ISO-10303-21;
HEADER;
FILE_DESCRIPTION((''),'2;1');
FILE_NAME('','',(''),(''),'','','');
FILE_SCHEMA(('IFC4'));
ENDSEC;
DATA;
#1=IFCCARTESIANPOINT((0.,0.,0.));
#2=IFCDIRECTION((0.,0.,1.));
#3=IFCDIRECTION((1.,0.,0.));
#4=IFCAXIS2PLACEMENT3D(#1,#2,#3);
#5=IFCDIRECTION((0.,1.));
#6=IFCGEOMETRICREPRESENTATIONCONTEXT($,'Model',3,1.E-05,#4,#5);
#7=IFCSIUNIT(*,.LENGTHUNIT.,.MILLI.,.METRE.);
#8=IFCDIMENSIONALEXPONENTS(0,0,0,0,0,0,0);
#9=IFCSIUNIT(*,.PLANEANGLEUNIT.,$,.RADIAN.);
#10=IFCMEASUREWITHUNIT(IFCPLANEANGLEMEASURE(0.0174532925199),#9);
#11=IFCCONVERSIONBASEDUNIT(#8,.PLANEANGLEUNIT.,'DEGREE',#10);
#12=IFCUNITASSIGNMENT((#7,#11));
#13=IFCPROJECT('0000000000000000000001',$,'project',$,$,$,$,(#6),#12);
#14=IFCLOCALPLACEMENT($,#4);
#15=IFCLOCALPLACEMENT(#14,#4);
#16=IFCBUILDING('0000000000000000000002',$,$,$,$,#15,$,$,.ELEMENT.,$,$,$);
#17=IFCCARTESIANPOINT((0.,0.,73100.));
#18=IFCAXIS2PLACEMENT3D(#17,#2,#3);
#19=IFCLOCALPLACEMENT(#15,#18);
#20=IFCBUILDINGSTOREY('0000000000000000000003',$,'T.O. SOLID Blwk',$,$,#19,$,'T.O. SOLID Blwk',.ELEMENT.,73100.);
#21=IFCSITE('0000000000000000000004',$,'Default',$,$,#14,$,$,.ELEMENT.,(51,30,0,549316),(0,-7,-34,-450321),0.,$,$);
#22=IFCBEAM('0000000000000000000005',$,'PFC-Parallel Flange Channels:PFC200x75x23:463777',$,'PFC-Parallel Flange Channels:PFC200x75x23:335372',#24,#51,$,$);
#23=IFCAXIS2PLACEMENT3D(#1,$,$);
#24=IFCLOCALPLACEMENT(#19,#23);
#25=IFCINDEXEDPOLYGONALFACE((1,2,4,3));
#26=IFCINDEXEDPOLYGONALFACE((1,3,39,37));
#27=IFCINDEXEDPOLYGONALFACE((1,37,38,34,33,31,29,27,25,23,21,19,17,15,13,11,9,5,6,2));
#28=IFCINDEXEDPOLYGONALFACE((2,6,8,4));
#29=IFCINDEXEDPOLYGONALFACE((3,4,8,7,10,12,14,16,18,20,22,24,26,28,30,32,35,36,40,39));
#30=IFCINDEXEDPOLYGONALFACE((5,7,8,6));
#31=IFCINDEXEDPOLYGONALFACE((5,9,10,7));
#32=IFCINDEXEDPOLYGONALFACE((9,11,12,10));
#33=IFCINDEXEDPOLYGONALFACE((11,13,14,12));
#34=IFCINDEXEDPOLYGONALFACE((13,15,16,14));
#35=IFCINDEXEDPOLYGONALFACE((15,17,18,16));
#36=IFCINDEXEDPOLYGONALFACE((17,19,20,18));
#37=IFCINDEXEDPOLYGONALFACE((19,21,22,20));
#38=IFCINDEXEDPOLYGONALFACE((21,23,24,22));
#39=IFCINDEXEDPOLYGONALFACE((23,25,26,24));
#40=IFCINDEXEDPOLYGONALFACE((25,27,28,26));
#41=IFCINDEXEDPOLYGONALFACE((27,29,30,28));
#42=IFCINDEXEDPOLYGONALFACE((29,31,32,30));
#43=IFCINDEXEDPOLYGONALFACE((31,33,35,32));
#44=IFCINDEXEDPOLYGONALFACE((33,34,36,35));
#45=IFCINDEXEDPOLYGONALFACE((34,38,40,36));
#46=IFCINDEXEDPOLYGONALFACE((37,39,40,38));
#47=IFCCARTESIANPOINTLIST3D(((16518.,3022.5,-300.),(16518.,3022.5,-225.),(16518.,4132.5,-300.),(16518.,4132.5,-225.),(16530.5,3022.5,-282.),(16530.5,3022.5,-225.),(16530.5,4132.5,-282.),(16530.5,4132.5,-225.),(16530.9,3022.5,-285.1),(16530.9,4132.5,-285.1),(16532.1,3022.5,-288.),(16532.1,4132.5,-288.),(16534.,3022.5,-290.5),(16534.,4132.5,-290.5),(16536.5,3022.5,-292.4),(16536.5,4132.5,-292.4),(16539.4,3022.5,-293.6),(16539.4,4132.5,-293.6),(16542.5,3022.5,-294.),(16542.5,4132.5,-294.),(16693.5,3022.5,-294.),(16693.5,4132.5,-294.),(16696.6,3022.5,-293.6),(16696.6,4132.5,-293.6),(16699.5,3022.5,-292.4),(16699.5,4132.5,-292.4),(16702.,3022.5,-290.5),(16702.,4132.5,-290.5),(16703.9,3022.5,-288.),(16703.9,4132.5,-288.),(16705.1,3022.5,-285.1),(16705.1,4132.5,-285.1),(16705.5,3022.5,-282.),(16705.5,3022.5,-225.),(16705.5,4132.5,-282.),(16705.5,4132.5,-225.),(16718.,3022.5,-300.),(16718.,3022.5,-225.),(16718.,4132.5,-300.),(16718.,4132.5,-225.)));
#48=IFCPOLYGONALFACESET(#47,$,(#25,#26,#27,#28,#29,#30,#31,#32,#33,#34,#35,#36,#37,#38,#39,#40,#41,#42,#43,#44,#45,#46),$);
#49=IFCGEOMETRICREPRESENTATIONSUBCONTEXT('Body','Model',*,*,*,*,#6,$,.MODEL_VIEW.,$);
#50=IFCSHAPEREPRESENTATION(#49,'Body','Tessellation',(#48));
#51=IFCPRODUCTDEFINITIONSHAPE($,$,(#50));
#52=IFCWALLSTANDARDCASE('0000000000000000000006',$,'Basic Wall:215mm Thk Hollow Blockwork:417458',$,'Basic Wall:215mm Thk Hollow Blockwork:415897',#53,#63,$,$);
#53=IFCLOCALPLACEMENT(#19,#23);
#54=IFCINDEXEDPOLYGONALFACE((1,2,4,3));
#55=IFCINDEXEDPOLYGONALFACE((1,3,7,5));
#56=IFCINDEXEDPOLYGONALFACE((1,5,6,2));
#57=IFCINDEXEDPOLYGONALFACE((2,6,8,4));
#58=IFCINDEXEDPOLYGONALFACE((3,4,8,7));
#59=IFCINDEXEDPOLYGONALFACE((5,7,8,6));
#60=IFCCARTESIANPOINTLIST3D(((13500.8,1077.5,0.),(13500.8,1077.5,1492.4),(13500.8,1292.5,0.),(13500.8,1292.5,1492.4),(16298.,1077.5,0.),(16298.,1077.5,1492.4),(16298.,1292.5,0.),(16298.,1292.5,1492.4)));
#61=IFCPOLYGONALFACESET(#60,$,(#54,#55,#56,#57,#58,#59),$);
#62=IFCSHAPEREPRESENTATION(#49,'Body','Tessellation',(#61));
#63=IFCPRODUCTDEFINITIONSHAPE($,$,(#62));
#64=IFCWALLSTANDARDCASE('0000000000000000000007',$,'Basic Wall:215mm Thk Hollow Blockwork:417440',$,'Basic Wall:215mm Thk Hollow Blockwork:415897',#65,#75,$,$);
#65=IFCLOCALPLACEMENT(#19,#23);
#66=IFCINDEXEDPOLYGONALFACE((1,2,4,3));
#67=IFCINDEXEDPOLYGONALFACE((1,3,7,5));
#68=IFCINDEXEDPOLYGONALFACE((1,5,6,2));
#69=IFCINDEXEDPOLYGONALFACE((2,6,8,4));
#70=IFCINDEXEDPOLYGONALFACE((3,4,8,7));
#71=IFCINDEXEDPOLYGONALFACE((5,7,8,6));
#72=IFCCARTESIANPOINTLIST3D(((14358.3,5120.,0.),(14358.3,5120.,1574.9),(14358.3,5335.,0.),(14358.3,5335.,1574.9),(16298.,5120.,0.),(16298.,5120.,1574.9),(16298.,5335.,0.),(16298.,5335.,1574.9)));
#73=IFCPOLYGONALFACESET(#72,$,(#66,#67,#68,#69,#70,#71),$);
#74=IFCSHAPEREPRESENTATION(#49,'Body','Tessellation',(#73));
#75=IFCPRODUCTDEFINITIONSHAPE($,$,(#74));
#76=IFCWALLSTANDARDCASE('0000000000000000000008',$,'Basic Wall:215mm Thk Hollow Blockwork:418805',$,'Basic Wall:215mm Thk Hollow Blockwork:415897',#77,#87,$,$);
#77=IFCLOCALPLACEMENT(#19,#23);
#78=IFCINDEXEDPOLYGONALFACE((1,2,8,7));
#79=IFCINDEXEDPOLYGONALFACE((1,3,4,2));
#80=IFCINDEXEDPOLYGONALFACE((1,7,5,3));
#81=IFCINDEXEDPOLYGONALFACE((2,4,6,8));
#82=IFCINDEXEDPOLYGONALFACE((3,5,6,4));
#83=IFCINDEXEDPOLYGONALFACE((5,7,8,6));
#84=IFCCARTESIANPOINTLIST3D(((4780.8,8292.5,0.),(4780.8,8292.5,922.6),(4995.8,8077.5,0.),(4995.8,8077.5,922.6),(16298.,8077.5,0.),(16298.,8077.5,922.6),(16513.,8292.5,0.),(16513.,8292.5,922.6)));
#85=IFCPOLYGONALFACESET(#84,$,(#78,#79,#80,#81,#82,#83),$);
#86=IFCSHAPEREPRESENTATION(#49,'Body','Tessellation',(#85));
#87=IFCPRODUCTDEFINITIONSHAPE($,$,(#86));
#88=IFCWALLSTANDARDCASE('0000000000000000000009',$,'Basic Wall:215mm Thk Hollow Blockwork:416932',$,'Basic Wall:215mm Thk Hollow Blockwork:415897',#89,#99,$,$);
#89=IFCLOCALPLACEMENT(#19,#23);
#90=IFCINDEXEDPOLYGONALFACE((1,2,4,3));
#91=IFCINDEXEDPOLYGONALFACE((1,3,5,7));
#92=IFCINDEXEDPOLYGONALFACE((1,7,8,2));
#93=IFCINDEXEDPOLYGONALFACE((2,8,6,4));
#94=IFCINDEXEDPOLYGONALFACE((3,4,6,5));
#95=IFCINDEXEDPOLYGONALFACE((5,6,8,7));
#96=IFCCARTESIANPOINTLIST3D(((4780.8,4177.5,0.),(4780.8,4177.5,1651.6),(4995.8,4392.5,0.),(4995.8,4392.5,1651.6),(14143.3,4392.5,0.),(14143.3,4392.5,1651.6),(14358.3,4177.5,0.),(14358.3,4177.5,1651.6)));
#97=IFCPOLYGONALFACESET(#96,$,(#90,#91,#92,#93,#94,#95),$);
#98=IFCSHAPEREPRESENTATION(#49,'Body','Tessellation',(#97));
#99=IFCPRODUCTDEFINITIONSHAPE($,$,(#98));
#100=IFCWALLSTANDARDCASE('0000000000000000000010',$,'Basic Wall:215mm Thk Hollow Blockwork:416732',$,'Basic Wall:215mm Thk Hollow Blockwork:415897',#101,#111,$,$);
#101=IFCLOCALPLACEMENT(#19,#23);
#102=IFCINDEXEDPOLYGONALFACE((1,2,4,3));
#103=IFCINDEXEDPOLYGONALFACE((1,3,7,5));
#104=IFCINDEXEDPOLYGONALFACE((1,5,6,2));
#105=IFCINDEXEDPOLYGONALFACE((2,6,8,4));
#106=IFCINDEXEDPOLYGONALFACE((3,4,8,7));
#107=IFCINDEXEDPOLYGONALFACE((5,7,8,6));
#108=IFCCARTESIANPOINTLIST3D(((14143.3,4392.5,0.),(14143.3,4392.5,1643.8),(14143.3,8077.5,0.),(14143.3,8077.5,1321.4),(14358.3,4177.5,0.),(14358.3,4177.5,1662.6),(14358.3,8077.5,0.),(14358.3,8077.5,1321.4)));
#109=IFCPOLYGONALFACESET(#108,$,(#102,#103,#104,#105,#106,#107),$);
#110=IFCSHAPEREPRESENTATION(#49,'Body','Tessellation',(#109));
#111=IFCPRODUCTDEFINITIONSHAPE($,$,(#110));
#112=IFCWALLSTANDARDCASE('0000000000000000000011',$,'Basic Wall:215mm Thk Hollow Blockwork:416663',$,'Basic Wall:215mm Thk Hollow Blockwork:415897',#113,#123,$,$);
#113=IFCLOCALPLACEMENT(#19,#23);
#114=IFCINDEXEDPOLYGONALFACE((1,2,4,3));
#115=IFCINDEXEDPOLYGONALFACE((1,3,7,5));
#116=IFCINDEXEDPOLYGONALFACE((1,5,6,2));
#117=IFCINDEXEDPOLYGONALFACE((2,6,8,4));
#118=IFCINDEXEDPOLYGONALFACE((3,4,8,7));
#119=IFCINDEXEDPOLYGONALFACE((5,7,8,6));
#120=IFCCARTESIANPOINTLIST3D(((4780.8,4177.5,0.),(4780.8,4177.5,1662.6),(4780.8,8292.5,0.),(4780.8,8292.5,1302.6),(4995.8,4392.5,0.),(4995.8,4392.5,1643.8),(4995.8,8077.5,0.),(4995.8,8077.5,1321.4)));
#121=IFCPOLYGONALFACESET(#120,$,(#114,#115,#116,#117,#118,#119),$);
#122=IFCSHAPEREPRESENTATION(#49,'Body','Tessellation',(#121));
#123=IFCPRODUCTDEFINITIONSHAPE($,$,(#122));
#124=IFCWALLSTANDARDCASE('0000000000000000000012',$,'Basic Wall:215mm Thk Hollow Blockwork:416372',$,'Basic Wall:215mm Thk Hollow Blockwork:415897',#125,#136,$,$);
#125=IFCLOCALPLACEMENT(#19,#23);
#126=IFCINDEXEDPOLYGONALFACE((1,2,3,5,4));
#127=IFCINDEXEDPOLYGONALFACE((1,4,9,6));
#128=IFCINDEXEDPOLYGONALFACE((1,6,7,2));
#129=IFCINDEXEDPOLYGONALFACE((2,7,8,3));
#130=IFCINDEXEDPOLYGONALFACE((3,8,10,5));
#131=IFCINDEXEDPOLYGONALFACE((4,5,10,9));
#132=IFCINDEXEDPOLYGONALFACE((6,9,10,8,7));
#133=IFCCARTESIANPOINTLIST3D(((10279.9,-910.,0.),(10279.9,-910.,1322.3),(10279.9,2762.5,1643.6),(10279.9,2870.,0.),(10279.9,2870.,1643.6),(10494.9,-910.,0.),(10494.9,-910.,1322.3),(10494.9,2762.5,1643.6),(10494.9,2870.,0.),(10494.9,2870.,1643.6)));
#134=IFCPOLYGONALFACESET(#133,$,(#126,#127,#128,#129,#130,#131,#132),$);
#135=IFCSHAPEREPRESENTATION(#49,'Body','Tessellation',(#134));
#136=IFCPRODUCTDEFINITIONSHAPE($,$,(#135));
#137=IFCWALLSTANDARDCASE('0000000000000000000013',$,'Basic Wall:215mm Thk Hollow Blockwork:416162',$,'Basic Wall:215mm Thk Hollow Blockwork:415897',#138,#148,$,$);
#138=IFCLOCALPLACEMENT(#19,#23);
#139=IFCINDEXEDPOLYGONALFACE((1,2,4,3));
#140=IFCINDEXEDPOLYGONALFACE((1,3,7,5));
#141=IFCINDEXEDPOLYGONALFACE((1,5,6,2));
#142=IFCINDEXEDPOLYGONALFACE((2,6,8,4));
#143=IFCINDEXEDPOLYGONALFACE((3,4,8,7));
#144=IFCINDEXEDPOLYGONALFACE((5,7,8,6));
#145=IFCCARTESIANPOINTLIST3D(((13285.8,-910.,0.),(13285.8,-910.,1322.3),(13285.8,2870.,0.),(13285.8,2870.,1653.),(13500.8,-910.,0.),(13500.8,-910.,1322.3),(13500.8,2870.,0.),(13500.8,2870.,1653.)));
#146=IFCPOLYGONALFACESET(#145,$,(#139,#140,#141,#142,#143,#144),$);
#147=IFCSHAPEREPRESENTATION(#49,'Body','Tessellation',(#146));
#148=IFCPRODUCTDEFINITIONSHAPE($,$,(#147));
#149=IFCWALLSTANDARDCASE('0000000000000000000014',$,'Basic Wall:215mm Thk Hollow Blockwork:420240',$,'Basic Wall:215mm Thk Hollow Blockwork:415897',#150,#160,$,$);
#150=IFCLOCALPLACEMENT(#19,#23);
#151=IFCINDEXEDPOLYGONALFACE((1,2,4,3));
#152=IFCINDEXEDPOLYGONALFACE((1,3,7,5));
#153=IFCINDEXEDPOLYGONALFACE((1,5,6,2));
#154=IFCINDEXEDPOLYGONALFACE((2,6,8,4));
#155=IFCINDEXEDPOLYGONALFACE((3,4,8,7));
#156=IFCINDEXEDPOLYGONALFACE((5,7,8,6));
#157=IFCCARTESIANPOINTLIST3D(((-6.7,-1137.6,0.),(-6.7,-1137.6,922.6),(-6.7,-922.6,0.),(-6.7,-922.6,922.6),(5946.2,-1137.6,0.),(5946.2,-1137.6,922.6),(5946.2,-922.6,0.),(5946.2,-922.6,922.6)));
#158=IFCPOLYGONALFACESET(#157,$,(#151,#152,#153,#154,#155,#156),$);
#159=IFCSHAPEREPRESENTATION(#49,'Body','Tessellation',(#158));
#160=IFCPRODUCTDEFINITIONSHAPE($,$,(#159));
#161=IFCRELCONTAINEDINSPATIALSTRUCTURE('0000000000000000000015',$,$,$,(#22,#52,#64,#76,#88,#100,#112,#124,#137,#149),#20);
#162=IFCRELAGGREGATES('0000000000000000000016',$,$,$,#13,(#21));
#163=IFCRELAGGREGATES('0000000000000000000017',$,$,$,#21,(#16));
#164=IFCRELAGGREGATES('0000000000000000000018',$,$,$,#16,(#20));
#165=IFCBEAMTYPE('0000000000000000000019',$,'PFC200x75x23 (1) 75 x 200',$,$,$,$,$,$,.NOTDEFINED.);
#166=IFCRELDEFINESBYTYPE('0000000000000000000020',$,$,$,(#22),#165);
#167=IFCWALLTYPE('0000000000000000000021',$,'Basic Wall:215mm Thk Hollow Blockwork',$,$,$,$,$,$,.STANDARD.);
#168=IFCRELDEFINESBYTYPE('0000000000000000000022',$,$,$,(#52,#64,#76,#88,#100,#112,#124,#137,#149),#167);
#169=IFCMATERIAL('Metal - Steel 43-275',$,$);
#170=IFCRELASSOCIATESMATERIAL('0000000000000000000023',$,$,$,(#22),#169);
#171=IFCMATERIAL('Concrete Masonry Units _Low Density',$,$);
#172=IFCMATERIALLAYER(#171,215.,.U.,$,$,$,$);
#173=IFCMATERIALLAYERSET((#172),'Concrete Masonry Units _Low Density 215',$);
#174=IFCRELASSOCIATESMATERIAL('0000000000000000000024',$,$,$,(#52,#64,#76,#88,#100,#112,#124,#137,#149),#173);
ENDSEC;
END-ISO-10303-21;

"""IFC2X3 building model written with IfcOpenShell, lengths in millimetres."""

from ifc_helpers import new_model, entity, si_unit, converted_unit, point, direction, frame, frame_2d, origin_with_axes, place, context, subcontext, project, spatial, polyline, circle_curve, parameter, trimmed, segment, composite_curve, outline, extrude, clip, halfspace, material, layer, layer_set, layer_usage, type_object, element, save


model = new_model("IFC2X3")

# Units and contexts
model_context = context("Model", 3, precision=1e-05, world=origin_with_axes(), true_north=direction((0.0, 1.0)))
body_context = subcontext(model_context, "Body", "Model", "MODEL_VIEW")
ifc_project = project(units=[si_unit("LENGTHUNIT", "METRE", prefix="MILLI"), converted_unit("PLANEANGLEUNIT", "DEGREE", entity("IfcPlaneAngleMeasure", 0.0174532925199), si_unit("PLANEANGLEUNIT", "RADIAN"), dimensions=[0, 0, 0, 0, 0, 0, 0])], contexts=[model_context])

# Site, building, storey
site_placement = place(None, origin_with_axes())
site = spatial("IfcSite", under=ifc_project, at=site_placement, Name="Default", CompositionType="ELEMENT", RefLatitude=(51, 30, 0, 549316), RefLongitude=(0, -7, -34, -450321), RefElevation=0.0)
building_placement = place(site_placement, origin_with_axes())
building = spatial("IfcBuilding", under=site, at=building_placement, CompositionType="ELEMENT")
storey_placement = place(building_placement, frame((0.0, 0.0, 73100.0), z_axis=(0.0, 0.0, 1.0), x_axis=(1.0, 0.0, 0.0)))
storey = spatial("IfcBuildingStorey", under=building, at=storey_placement, Name="T.O. SOLID Blwk", LongName="T.O. SOLID Blwk", CompositionType="ELEMENT", Elevation=73100.0)

# Beam
ifc_material_1 = material(Name="Metal - Steel 43-275")
beam_type = type_object("IfcBeamType", Name="PFC200x75x23 (1) 75 x 200", PredefinedType="NOTDEFINED")
beam_placement = place(storey_placement, frame((16618.0, 3022.5, -265.2), z_axis=(0.0, 0.0, 1.0), x_axis=(1.0, 0.0, 0.0)))
element("IfcBeam", 1, at=beam_placement, inside=storey, type_object=beam_type, material=ifc_material_1, Name="PFC-Parallel Flange Channels:PFC200x75x23:463777", ObjectType="PFC-Parallel Flange Channels:PFC200x75x23:335372", context=body_context, shape_type="SweptSolid", body=[
    extrude(outline(composite_curve([segment(polyline([(-40.2, -100.0), (34.8, -100.0), (34.8, 100.0), (-40.2, 100.0), (-40.2, 87.5), (16.8, 87.5)]), True, "CONTINUOUS"), segment(trimmed(circle_curve(frame_2d((16.8, 75.5), x_axis=(1.0, 0.0)), 12.0), [point((16.8, 87.5)), parameter(90.0)], [point((28.8, 75.5)), parameter(0.0)], False, "CARTESIAN"), True, "CONTINUOUS"), segment(polyline([(28.8, 75.5), (28.8, -75.5)]), True, "CONTINUOUS"), segment(trimmed(circle_curve(frame_2d((16.8, -75.5), x_axis=(0.0, -1.0)), 12.0), [point((28.8, -75.5)), parameter(90.0)], [point((16.8, -87.5)), parameter(0.0)], False, "CARTESIAN"), True, "CONTINUOUS"), segment(polyline([(16.8, -87.5), (-40.2, -87.5), (-40.2, -100.0)]), True, "CONTINUOUS")], self_intersect=False)), frame((0.0, 1110.0, 0.0), z_axis=(0.0, -1.0, 0.0), x_axis=(0.0, 0.0, -1.0)), (0.0, 0.0, 1.0), 1110.0),
])

# Shared definitions
ifc_material_2 = material(Name="Concrete Masonry Units _Low Density")
ifc_layer = layer(ifc_material_2, 215.0, ventilated="UNKNOWN")
ifc_layer_set = layer_set([ifc_layer], Name="Concrete Masonry Units _Low Density 215")
wall_type = type_object("IfcWallType", Name="Basic Wall:215mm Thk Hollow Blockwork", PredefinedType="STANDARD")

# Walls
ifc_layer_usage_1 = layer_usage(ifc_layer_set, "AXIS2", "POSITIVE", -107.5)
wall_1_placement = place(storey_placement, frame((13393.3, 1185.0, 0.0), z_axis=(0.0, 0.0, 1.0), x_axis=(1.0, 0.0, 0.0)))
element("IfcWallStandardCase", 2, at=wall_1_placement, inside=storey, type_object=wall_type, material=ifc_layer_usage_1, Name="Basic Wall:215mm Thk Hollow Blockwork:417458", ObjectType="Basic Wall:215mm Thk Hollow Blockwork:415897", context=body_context, shape_type="SweptSolid", body=[
    extrude(outline(polyline([(107.5, -107.5), (2904.8, -107.5), (2904.8, 107.5), (107.5, 107.5), (107.5, -107.5)])), origin_with_axes(), (0.0, 0.0, 1.0), 1492.4),
])
ifc_layer_usage_2 = layer_usage(ifc_layer_set, "AXIS2", "POSITIVE", -107.5)
wall_2_placement = place(storey_placement, frame((14250.8, 5227.5, 0.0), z_axis=(0.0, 0.0, 1.0), x_axis=(1.0, 0.0, 0.0)))
element("IfcWallStandardCase", 3, at=wall_2_placement, inside=storey, type_object=wall_type, material=ifc_layer_usage_2, Name="Basic Wall:215mm Thk Hollow Blockwork:417440", ObjectType="Basic Wall:215mm Thk Hollow Blockwork:415897", context=body_context, shape_type="SweptSolid", body=[
    extrude(outline(polyline([(107.5, -107.5), (2047.3, -107.5), (2047.3, 107.5), (107.5, 107.5), (107.5, -107.5)])), origin_with_axes(), (0.0, 0.0, 1.0), 1574.9),
])
ifc_layer_usage_3 = layer_usage(ifc_layer_set, "AXIS2", "POSITIVE", -107.5)
wall_3_placement = place(storey_placement, frame((4888.3, 8185.0, 0.0), z_axis=(0.0, 0.0, 1.0), x_axis=(1.0, 0.0, 0.0)))
element("IfcWallStandardCase", 4, at=wall_3_placement, inside=storey, type_object=wall_type, material=ifc_layer_usage_3, Name="Basic Wall:215mm Thk Hollow Blockwork:418805", ObjectType="Basic Wall:215mm Thk Hollow Blockwork:415897", context=body_context, shape_type="SweptSolid", body=[
    extrude(outline(polyline([(107.5, -107.5), (11409.8, -107.5), (11624.8, 107.5), (-107.5, 107.5), (107.5, -107.5)])), origin_with_axes(), (0.0, 0.0, 1.0), 922.6),
])
ifc_layer_usage_4 = layer_usage(ifc_layer_set, "AXIS2", "POSITIVE", -107.5)
wall_4_placement = place(storey_placement, frame((4888.3, 4285.0, 0.0), z_axis=(0.0, 0.0, 1.0), x_axis=(1.0, 0.0, 0.0)))
element("IfcWallStandardCase", 5, at=wall_4_placement, inside=storey, type_object=wall_type, material=ifc_layer_usage_4, Name="Basic Wall:215mm Thk Hollow Blockwork:416932", ObjectType="Basic Wall:215mm Thk Hollow Blockwork:415897", context=body_context, shape_type="SweptSolid", body=[
    extrude(outline(polyline([(-107.5, -107.5), (9470.0, -107.5), (9255.0, 107.5), (107.5, 107.5), (-107.5, -107.5)])), origin_with_axes(), (0.0, 0.0, 1.0), 1651.6),
])
ifc_layer_usage_5 = layer_usage(ifc_layer_set, "AXIS2", "POSITIVE", -107.5)
wall_5_placement = place(storey_placement, frame((14250.8, 4285.0, 0.0), z_axis=(0.0, 0.0, 1.0), x_axis=(0.0, 1.0, 0.0)))
element("IfcWallStandardCase", 6, at=wall_5_placement, inside=storey, type_object=wall_type, material=ifc_layer_usage_5, Name="Basic Wall:215mm Thk Hollow Blockwork:416732", ObjectType="Basic Wall:215mm Thk Hollow Blockwork:415897", context=body_context, shape_type="Clipping", body=[
    clip(extrude(outline(polyline([(-107.5, -107.5), (3792.5, -107.5), (3792.5, 107.5), (107.5, 107.5), (-107.5, -107.5)])), origin_with_axes(), (0.0, 0.0, 1.0), 1662.6), halfspace(frame((143.5, 0.0, 1640.7), z_axis=(-0.087156, 0.0, -0.996195), x_axis=(0.0, 1.0, 0.0)), True)),
])
ifc_layer_usage_6 = layer_usage(ifc_layer_set, "AXIS2", "POSITIVE", -107.5)
wall_6_placement = place(storey_placement, frame((4888.3, 8185.0, 0.0), z_axis=(0.0, 0.0, 1.0), x_axis=(0.0, -1.0, 0.0)))
element("IfcWallStandardCase", 7, at=wall_6_placement, inside=storey, type_object=wall_type, material=ifc_layer_usage_6, Name="Basic Wall:215mm Thk Hollow Blockwork:416663", ObjectType="Basic Wall:215mm Thk Hollow Blockwork:415897", context=body_context, shape_type="Clipping", body=[
    clip(extrude(outline(polyline([(-107.5, -107.5), (4007.5, -107.5), (3792.5, 107.5), (107.5, 107.5), (-107.5, -107.5)])), origin_with_axes(), (0.0, 0.0, 1.0), 1662.6), halfspace(frame((-113.9, 0.0, 1302.0), z_axis=(0.087156, 0.0, -0.996195), x_axis=(0.0, 1.0, 0.0)), True)),
])
ifc_layer_usage_7 = layer_usage(ifc_layer_set, "AXIS2", "POSITIVE", -107.5)
wall_7_placement = place(storey_placement, frame((10387.4, -910.0, 0.0), z_axis=(0.0, 0.0, 1.0), x_axis=(0.0, 1.0, 0.0)))
element("IfcWallStandardCase", 8, at=wall_7_placement, inside=storey, type_object=wall_type, material=ifc_layer_usage_7, Name="Basic Wall:215mm Thk Hollow Blockwork:416372", ObjectType="Basic Wall:215mm Thk Hollow Blockwork:415897", context=body_context, shape_type="Clipping", body=[
    clip(extrude(outline(polyline([(0.0, -107.5), (3780.0, -107.5), (3780.0, 107.5), (0.0, 107.5), (0.0, -107.5)])), origin_with_axes(), (0.0, 0.0, 1.0), 1643.6), halfspace(frame((-114.8, 0.0, 1312.3), z_axis=(0.087156, 0.0, -0.996195), x_axis=(0.0, 1.0, 0.0)), True)),
])
ifc_layer_usage_8 = layer_usage(ifc_layer_set, "AXIS2", "POSITIVE", -107.5)
wall_8_placement = place(storey_placement, frame((13393.3, 2870.0, 0.0), z_axis=(0.0, 0.0, 1.0), x_axis=(0.0, -1.0, 0.0)))
element("IfcWallStandardCase", 9, at=wall_8_placement, inside=storey, type_object=wall_type, material=ifc_layer_usage_8, Name="Basic Wall:215mm Thk Hollow Blockwork:416162", ObjectType="Basic Wall:215mm Thk Hollow Blockwork:415897", context=body_context, shape_type="Clipping", body=[
    clip(extrude(outline(polyline([(0.0, -107.5), (3780.0, -107.5), (3780.0, 107.5), (0.0, 107.5), (0.0, -107.5)])), origin_with_axes(), (0.0, 0.0, 1.0), 1662.4), halfspace(frame((143.5, 0.0, 1640.5), z_axis=(-0.087156, 0.0, -0.996195), x_axis=(0.0, 1.0, 0.0)), True)),
])
ifc_layer_usage_9 = layer_usage(ifc_layer_set, "AXIS2", "POSITIVE", -107.5)
wall_9_placement = place(storey_placement, frame((-6.7, -1030.1, 0.0), z_axis=(0.0, 0.0, 1.0), x_axis=(1.0, 0.0, 0.0)))
element("IfcWallStandardCase", 10, at=wall_9_placement, inside=storey, type_object=wall_type, material=ifc_layer_usage_9, Name="Basic Wall:215mm Thk Hollow Blockwork:420240", ObjectType="Basic Wall:215mm Thk Hollow Blockwork:415897", context=body_context, shape_type="SweptSolid", body=[
    extrude(outline(polyline([(0.0, -107.5), (5952.9, -107.5), (5952.9, 107.5), (0.0, 107.5), (0.0, -107.5)])), origin_with_axes(), (0.0, 0.0, 1.0), 922.6),
])

save(model, "model.ifc")
